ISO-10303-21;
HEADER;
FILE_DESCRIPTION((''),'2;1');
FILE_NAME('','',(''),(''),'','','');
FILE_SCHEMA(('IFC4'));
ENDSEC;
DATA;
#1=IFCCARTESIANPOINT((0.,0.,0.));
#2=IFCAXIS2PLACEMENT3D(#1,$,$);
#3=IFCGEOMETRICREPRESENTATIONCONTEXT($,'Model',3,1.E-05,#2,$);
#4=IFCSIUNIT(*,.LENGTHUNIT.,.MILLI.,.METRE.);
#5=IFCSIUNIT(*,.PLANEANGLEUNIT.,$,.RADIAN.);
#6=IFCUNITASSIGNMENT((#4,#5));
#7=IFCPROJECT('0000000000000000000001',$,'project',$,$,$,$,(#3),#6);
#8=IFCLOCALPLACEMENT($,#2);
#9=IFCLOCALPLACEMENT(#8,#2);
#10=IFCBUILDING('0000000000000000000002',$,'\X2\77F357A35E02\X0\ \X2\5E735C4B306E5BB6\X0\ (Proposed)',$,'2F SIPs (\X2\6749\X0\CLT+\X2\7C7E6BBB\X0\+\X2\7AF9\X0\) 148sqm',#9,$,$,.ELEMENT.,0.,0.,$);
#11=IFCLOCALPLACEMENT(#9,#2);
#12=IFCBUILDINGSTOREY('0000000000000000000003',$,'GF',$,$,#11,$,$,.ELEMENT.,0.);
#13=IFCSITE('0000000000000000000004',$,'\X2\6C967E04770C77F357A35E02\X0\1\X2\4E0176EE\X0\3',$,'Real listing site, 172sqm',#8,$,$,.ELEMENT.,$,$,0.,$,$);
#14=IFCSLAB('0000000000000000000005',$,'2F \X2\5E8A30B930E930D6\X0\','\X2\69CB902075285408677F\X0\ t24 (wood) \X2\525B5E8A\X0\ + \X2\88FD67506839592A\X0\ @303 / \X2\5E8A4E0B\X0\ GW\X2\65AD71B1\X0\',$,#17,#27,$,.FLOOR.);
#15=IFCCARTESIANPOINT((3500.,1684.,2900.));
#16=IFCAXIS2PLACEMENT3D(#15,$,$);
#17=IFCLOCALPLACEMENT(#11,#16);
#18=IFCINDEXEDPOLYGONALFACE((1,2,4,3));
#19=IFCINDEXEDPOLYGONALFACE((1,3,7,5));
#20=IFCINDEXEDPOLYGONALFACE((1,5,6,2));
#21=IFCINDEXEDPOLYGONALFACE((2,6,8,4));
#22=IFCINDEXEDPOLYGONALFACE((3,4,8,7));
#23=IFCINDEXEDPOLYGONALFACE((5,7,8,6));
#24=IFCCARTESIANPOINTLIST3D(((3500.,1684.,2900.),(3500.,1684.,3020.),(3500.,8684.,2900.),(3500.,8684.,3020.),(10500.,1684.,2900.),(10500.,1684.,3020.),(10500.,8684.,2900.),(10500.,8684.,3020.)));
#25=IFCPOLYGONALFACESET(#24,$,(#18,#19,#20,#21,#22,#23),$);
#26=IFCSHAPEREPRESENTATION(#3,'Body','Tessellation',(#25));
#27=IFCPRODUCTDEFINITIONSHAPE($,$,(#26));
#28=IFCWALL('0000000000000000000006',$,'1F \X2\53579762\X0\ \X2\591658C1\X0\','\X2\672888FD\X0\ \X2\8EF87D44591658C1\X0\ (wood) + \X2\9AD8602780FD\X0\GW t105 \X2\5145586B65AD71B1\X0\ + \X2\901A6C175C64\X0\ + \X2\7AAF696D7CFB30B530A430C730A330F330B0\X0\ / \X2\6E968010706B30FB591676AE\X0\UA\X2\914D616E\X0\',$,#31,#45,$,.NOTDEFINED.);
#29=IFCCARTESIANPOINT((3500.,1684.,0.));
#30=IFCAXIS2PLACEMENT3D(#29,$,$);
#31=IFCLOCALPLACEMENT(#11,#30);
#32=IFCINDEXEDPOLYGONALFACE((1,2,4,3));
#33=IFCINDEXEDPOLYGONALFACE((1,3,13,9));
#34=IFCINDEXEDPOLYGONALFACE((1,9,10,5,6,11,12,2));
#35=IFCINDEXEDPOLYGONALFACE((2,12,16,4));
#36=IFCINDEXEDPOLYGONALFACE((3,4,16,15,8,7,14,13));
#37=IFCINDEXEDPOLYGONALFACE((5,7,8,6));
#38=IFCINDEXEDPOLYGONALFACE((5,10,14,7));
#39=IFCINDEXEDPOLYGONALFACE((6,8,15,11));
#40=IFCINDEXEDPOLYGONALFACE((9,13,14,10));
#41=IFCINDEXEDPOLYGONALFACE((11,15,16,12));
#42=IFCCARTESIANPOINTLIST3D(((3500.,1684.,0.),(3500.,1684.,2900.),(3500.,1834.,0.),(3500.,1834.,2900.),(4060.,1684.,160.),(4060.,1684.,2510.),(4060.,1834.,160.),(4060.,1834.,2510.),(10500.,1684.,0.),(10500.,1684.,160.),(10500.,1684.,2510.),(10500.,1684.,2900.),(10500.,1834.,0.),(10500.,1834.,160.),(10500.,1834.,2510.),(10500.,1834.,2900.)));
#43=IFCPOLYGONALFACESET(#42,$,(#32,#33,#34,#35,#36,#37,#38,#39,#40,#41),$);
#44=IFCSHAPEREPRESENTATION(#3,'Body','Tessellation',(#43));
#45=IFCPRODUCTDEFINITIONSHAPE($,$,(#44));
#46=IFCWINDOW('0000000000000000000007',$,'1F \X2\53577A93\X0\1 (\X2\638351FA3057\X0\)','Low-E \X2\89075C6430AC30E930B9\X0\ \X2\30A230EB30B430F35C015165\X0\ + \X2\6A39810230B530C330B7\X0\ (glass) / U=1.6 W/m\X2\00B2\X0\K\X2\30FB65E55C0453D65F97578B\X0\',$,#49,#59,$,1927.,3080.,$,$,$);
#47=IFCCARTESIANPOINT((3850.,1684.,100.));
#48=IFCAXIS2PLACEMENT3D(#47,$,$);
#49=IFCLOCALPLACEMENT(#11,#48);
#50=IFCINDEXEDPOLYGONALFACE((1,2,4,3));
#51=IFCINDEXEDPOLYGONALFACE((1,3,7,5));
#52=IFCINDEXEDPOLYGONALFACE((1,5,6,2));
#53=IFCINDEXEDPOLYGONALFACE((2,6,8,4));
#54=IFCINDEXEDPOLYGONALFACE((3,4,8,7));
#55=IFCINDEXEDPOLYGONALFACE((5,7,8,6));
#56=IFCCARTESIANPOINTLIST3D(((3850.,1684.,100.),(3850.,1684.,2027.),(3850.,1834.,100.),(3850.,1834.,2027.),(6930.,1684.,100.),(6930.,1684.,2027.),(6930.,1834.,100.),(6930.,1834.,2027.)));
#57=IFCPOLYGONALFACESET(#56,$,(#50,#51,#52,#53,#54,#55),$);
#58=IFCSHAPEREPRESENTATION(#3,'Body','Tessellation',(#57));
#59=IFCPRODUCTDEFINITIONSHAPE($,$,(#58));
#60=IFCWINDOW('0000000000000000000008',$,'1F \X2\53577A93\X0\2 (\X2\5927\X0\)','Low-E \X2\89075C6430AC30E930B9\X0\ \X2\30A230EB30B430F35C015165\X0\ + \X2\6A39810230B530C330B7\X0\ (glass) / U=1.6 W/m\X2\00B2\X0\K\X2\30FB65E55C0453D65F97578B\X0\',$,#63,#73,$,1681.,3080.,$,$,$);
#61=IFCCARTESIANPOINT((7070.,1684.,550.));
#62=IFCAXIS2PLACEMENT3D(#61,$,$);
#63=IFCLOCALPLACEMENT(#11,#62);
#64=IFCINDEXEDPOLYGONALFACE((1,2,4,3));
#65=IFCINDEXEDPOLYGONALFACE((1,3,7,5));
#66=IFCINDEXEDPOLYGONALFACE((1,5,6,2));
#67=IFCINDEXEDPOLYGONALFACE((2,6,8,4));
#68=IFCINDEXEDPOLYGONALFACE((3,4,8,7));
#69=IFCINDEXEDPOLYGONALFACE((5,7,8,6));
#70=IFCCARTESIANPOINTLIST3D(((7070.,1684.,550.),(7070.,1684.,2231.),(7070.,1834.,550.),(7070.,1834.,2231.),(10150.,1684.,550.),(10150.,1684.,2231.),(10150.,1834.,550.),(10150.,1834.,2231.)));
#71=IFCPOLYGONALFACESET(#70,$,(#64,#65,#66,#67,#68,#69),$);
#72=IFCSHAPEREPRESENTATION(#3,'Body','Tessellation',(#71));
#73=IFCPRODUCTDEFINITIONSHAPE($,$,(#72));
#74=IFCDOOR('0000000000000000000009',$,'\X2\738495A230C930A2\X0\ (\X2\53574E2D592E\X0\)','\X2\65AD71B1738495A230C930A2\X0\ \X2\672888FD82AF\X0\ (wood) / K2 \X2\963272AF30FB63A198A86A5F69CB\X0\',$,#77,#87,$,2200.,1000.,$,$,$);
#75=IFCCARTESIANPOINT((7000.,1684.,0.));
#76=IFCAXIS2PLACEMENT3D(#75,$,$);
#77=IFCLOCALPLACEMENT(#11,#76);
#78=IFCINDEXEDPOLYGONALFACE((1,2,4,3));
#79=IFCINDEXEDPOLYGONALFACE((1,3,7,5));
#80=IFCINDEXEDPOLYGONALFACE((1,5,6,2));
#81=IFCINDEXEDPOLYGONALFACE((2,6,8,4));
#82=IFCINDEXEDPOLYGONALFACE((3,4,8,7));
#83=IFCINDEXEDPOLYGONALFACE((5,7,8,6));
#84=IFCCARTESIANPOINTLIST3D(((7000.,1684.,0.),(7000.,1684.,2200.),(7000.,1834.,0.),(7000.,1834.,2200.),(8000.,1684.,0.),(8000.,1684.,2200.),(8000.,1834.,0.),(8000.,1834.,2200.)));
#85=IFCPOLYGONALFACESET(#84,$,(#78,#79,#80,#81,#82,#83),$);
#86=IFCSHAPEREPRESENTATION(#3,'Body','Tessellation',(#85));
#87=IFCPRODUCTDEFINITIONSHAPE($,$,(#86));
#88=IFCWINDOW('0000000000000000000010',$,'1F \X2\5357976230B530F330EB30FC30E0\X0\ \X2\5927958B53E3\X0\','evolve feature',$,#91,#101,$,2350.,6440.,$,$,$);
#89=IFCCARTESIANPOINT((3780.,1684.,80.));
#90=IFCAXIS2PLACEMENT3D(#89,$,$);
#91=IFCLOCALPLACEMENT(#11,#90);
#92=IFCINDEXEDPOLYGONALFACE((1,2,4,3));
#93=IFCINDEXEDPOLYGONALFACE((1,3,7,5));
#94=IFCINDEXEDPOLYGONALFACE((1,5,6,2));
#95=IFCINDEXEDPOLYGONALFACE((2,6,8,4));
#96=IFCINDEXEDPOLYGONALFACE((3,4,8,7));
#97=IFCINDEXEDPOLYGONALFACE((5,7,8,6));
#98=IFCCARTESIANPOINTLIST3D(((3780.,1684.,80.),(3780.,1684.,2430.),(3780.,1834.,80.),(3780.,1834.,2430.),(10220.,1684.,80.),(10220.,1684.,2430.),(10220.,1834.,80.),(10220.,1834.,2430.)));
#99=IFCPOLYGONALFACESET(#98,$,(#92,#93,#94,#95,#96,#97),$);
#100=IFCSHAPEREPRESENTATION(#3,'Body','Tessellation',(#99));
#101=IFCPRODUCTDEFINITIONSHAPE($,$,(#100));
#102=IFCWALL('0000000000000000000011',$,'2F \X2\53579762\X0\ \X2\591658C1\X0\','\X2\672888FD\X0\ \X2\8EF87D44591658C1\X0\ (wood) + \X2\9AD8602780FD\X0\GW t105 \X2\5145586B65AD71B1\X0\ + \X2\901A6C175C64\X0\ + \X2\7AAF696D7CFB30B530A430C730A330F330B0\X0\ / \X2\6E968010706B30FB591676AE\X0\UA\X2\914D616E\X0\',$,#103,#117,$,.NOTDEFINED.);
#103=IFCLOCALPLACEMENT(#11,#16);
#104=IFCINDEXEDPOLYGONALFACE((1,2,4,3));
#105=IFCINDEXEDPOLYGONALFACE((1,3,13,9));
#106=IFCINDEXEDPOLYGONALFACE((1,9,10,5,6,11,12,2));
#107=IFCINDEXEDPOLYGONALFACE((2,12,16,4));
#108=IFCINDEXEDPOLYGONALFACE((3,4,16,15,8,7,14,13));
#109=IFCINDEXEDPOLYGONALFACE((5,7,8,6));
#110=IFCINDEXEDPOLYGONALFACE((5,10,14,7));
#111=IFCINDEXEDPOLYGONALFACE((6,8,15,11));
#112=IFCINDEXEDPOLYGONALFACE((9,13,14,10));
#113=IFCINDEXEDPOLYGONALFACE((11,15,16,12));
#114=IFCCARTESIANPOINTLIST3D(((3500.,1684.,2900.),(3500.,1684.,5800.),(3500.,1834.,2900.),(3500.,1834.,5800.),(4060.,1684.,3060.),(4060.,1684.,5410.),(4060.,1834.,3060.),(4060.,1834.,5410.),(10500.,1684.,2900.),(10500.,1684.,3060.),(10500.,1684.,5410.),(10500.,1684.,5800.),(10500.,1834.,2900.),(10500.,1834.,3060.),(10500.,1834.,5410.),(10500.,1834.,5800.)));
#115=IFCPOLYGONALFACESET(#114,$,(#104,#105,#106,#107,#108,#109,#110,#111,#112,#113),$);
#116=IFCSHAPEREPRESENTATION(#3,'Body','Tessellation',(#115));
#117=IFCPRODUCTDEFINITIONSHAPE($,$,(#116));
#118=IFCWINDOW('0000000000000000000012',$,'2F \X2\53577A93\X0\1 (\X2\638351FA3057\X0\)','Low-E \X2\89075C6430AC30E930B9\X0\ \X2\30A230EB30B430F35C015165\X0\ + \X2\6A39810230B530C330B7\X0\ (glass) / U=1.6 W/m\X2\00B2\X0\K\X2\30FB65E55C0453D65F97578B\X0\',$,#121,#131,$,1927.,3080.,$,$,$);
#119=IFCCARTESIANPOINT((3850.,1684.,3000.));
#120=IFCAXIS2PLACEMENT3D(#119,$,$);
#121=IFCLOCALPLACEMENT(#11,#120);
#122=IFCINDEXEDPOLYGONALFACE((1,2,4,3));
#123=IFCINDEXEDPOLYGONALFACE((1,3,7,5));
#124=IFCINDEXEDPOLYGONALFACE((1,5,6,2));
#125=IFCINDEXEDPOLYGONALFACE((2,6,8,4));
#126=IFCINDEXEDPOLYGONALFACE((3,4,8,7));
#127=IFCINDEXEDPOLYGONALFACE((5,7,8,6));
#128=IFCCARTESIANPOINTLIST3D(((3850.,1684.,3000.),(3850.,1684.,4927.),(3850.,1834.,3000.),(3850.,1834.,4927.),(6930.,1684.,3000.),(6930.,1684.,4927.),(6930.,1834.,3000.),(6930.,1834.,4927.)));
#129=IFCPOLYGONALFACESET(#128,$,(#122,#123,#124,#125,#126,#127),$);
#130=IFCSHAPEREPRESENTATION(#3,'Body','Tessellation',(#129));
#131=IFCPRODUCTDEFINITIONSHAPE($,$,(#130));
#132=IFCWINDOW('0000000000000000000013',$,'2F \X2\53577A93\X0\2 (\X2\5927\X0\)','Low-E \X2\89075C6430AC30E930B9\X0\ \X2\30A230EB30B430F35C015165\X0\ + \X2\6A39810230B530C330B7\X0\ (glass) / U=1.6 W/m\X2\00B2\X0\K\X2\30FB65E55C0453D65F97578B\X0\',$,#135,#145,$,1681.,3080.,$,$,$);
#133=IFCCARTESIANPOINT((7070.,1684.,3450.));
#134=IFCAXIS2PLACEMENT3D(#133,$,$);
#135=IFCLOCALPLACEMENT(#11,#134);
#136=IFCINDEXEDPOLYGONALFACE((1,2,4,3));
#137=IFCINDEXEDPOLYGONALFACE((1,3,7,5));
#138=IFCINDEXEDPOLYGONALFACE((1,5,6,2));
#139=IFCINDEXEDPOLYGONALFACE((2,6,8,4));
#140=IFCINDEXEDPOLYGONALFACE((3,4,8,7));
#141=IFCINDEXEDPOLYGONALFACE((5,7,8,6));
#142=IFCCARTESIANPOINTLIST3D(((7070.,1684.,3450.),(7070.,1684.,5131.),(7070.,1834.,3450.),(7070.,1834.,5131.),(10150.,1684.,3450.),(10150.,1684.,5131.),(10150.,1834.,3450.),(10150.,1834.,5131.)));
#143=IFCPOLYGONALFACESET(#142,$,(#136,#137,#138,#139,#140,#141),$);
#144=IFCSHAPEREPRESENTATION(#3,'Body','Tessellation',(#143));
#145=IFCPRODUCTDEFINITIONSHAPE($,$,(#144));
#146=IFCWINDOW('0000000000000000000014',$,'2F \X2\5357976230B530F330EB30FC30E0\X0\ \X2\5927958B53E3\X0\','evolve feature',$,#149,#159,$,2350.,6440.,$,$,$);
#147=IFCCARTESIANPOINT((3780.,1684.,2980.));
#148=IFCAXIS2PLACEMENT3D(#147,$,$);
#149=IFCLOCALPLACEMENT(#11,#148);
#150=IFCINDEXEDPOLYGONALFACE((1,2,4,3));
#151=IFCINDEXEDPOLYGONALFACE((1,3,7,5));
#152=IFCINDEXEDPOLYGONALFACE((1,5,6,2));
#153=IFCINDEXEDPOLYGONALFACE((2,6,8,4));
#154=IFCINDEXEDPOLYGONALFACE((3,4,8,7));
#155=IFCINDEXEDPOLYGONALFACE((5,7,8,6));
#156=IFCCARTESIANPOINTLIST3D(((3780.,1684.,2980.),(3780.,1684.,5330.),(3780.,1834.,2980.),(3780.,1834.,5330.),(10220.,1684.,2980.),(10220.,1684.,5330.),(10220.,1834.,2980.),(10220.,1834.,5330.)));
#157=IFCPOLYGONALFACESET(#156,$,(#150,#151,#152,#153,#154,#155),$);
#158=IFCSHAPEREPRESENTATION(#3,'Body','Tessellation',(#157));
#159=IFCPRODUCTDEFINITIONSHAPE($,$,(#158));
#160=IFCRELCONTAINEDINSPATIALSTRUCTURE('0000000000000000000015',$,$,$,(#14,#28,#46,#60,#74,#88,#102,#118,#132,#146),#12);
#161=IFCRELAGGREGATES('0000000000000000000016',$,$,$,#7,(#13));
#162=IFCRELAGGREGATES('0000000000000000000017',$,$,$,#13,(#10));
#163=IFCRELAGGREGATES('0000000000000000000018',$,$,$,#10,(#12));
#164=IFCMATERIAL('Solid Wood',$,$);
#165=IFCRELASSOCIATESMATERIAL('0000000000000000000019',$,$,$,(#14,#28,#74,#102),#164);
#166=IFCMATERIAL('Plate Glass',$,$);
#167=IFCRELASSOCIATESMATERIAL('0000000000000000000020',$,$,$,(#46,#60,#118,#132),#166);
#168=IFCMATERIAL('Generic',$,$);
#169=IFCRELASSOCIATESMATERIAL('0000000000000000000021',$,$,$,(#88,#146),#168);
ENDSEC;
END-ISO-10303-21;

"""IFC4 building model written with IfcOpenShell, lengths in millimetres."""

from ifc_helpers import new_model, si_unit, frame, frame_2d, origin, place, context, project, spatial, rectangle, extrude, material, element, fill, save


model = new_model("IFC4")

# Units and contexts
model_context = context("Model", 3, precision=1e-05, world=origin())
ifc_project = project(units=[si_unit("LENGTHUNIT", "METRE", prefix="MILLI"), si_unit("PLANEANGLEUNIT", "RADIAN")], contexts=[model_context])

# Site, building, storey
site_placement = place(None, origin())
site = spatial("IfcSite", under=ifc_project, at=site_placement, Name="沖縄県石垣市1丁目3", ObjectType="Real listing site, 172sqm", CompositionType="ELEMENT", RefElevation=0.0)
building_placement = place(site_placement, origin())
building = spatial("IfcBuilding", under=site, at=building_placement, Name="石垣市 平屋の家 (Proposed)", ObjectType="2F SIPs (杉CLT+籾殻+竹) 148sqm", CompositionType="ELEMENT", ElevationOfRefHeight=0.0, ElevationOfTerrain=0.0)
storey_placement = place(building_placement, origin())
storey = spatial("IfcBuildingStorey", under=building, at=storey_placement, Name="GF", CompositionType="ELEMENT", Elevation=0.0)

# Slab
ifc_material_1 = material(Name="Solid Wood")
slab_1_placement = place(storey_placement, frame((3500.0, 1684.0, 2900.0)))
element("IfcSlab", 1, at=slab_1_placement, inside=storey, material=ifc_material_1, Name="2F 床スラブ", Description="構造用合板 t24 (wood) 剛床 + 製材根太 @303 / 床下 GW断熱", PredefinedType="FLOOR", context=model_context, shape_type="SweptSolid", body=[
    extrude(rectangle(XDim=7000.0, YDim=7000.0, at=frame_2d((3500.0, 3500.0))), frame((3500.0, 1684.0, 2900.0)), (0.0, 0.0, 1.0), 120.0),
])
ifc_material_2 = material(Name="Generic")

# Wall, openings, windows, door
wall_1_placement = place(storey_placement, frame((3500.0, 1684.0, 0.0)))
wall_1 = element("IfcWall", 2, at=wall_1_placement, inside=storey, material=ifc_material_1, Name="1F 南面 外壁", Description="木製 軸組外壁 (wood) + 高性能GW t105 充填断熱 + 通気層 + 窯業系サイディング / 準耐火・外皮UA配慮", PredefinedType="NOTDEFINED", context=model_context, shape_type="SweptSolid", body=[
    extrude(rectangle(XDim=7000.0, YDim=150.0, at=frame_2d((3500.0, 75.0))), frame((3500.0, 1684.0, 0.0)), (0.0, 0.0, 1.0), 2900.0),
])
opening_1_placement = place(storey_placement, frame((3850.0, 1684.0, 100.0)))
opening_1 = element("IfcOpeningElement", 3, at=opening_1_placement, cuts=wall_1, PredefinedType="NOTDEFINED", context=model_context, shape_type="SweptSolid", body=[
    extrude(rectangle(XDim=3080.0, YDim=150.0, at=frame_2d((1540.0, 75.0))), frame((3850.0, 1684.0, 100.0)), (0.0, 0.0, 1.0), 1927.0),
])
opening_2_placement = place(storey_placement, frame((7070.0, 1684.0, 550.0)))
opening_2 = element("IfcOpeningElement", 4, at=opening_2_placement, cuts=wall_1, PredefinedType="NOTDEFINED", context=model_context, shape_type="SweptSolid", body=[
    extrude(rectangle(XDim=3080.0, YDim=150.0, at=frame_2d((1540.0, 75.0))), frame((7070.0, 1684.0, 550.0)), (0.0, 0.0, 1.0), 1681.0),
])
opening_3_placement = place(storey_placement, frame((7000.0, 1684.0, 0.0)))
opening_3 = element("IfcOpeningElement", 5, at=opening_3_placement, cuts=wall_1, PredefinedType="NOTDEFINED", context=model_context, shape_type="SweptSolid", body=[
    extrude(rectangle(XDim=1000.0, YDim=150.0, at=frame_2d((500.0, 75.0))), frame((7000.0, 1684.0, 0.0)), (0.0, 0.0, 1.0), 2200.0),
])
opening_4_placement = place(storey_placement, frame((3780.0, 1684.0, 80.0)))
opening_4 = element("IfcOpeningElement", 6, at=opening_4_placement, cuts=wall_1, PredefinedType="NOTDEFINED", context=model_context, shape_type="SweptSolid", body=[
    extrude(rectangle(XDim=6440.0, YDim=150.0, at=frame_2d((3220.0, 75.0))), frame((3780.0, 1684.0, 80.0)), (0.0, 0.0, 1.0), 2350.0),
])
ifc_material_3 = material(Name="Plate Glass")
window_1_placement = place(storey_placement, frame((3850.0, 1684.0, 100.0)))
window_1 = element("IfcWindow", 7, at=window_1_placement, inside=storey, material=ifc_material_3, Name="1F 南窓1 (掃出し)", Description="Low-E 複層ガラス アルゴン封入 + 樹脂サッシ (glass) / U=1.6 W/m²K・日射取得型", OverallHeight=1927.0, OverallWidth=3080.0, context=model_context, shape_type="SweptSolid", body=[
    extrude(rectangle(XDim=3080.0, YDim=150.0, at=frame_2d((1540.0, 75.0))), frame((3850.0, 1684.0, 100.0)), (0.0, 0.0, 1.0), 1927.0),
])
fill(opening_1, window_1)
window_2_placement = place(storey_placement, frame((7070.0, 1684.0, 550.0)))
window_2 = element("IfcWindow", 8, at=window_2_placement, inside=storey, material=ifc_material_3, Name="1F 南窓2 (大)", Description="Low-E 複層ガラス アルゴン封入 + 樹脂サッシ (glass) / U=1.6 W/m²K・日射取得型", OverallHeight=1681.0, OverallWidth=3080.0, context=model_context, shape_type="SweptSolid", body=[
    extrude(rectangle(XDim=3080.0, YDim=150.0, at=frame_2d((1540.0, 75.0))), frame((7070.0, 1684.0, 550.0)), (0.0, 0.0, 1.0), 1681.0),
])
fill(opening_2, window_2)
door_placement = place(storey_placement, frame((7000.0, 1684.0, 0.0)))
door = element("IfcDoor", 9, at=door_placement, inside=storey, material=ifc_material_1, Name="玄関ドア (南中央)", Description="断熱玄関ドア 木製芯 (wood) / K2 防犯・採風機構", OverallHeight=2200.0, OverallWidth=1000.0, context=model_context, shape_type="SweptSolid", body=[
    extrude(rectangle(XDim=1000.0, YDim=150.0, at=frame_2d((500.0, 75.0))), frame((7000.0, 1684.0, 0.0)), (0.0, 0.0, 1.0), 2200.0),
])
fill(opening_3, door)
window_3_placement = place(storey_placement, frame((3780.0, 1684.0, 80.0)))
window_3 = element("IfcWindow", 10, at=window_3_placement, inside=storey, material=ifc_material_2, Name="1F 南面サンルーム 大開口", Description="evolve feature", OverallHeight=2350.0, OverallWidth=6440.0, context=model_context, shape_type="SweptSolid", body=[
    extrude(rectangle(XDim=6440.0, YDim=150.0, at=frame_2d((3220.0, 75.0))), frame((3780.0, 1684.0, 80.0)), (0.0, 0.0, 1.0), 2350.0),
])
fill(opening_4, window_3)

# Wall, openings, windows
wall_2_placement = place(storey_placement, frame((3500.0, 1684.0, 2900.0)))
wall_2 = element("IfcWall", 11, at=wall_2_placement, inside=storey, material=ifc_material_1, Name="2F 南面 外壁", Description="木製 軸組外壁 (wood) + 高性能GW t105 充填断熱 + 通気層 + 窯業系サイディング / 準耐火・外皮UA配慮", PredefinedType="NOTDEFINED", context=model_context, shape_type="SweptSolid", body=[
    extrude(rectangle(XDim=7000.0, YDim=150.0, at=frame_2d((3500.0, 75.0))), frame((3500.0, 1684.0, 2900.0)), (0.0, 0.0, 1.0), 2900.0),
])
opening_5_placement = place(storey_placement, frame((3850.0, 1684.0, 3000.0)))
opening_5 = element("IfcOpeningElement", 12, at=opening_5_placement, cuts=wall_2, PredefinedType="NOTDEFINED", context=model_context, shape_type="SweptSolid", body=[
    extrude(rectangle(XDim=3080.0, YDim=150.0, at=frame_2d((1540.0, 75.0))), frame((3850.0, 1684.0, 3000.0)), (0.0, 0.0, 1.0), 1927.0),
])
opening_6_placement = place(storey_placement, frame((7070.0, 1684.0, 3450.0)))
opening_6 = element("IfcOpeningElement", 13, at=opening_6_placement, cuts=wall_2, PredefinedType="NOTDEFINED", context=model_context, shape_type="SweptSolid", body=[
    extrude(rectangle(XDim=3080.0, YDim=150.0, at=frame_2d((1540.0, 75.0))), frame((7070.0, 1684.0, 3450.0)), (0.0, 0.0, 1.0), 1681.0),
])
opening_7_placement = place(storey_placement, frame((3780.0, 1684.0, 2980.0)))
opening_7 = element("IfcOpeningElement", 14, at=opening_7_placement, cuts=wall_2, PredefinedType="NOTDEFINED", context=model_context, shape_type="SweptSolid", body=[
    extrude(rectangle(XDim=6440.0, YDim=150.0, at=frame_2d((3220.0, 75.0))), frame((3780.0, 1684.0, 2980.0)), (0.0, 0.0, 1.0), 2350.0),
])
window_4_placement = place(storey_placement, frame((3850.0, 1684.0, 3000.0)))
window_4 = element("IfcWindow", 15, at=window_4_placement, inside=storey, material=ifc_material_3, Name="2F 南窓1 (掃出し)", Description="Low-E 複層ガラス アルゴン封入 + 樹脂サッシ (glass) / U=1.6 W/m²K・日射取得型", OverallHeight=1927.0, OverallWidth=3080.0, context=model_context, shape_type="SweptSolid", body=[
    extrude(rectangle(XDim=3080.0, YDim=150.0, at=frame_2d((1540.0, 75.0))), frame((3850.0, 1684.0, 3000.0)), (0.0, 0.0, 1.0), 1927.0),
])
fill(opening_5, window_4)
window_5_placement = place(storey_placement, frame((7070.0, 1684.0, 3450.0)))
window_5 = element("IfcWindow", 16, at=window_5_placement, inside=storey, material=ifc_material_3, Name="2F 南窓2 (大)", Description="Low-E 複層ガラス アルゴン封入 + 樹脂サッシ (glass) / U=1.6 W/m²K・日射取得型", OverallHeight=1681.0, OverallWidth=3080.0, context=model_context, shape_type="SweptSolid", body=[
    extrude(rectangle(XDim=3080.0, YDim=150.0, at=frame_2d((1540.0, 75.0))), frame((7070.0, 1684.0, 3450.0)), (0.0, 0.0, 1.0), 1681.0),
])
fill(opening_6, window_5)
window_6_placement = place(storey_placement, frame((3780.0, 1684.0, 2980.0)))
window_6 = element("IfcWindow", 17, at=window_6_placement, inside=storey, material=ifc_material_2, Name="2F 南面サンルーム 大開口", Description="evolve feature", OverallHeight=2350.0, OverallWidth=6440.0, context=model_context, shape_type="SweptSolid", body=[
    extrude(rectangle(XDim=6440.0, YDim=150.0, at=frame_2d((3220.0, 75.0))), frame((3780.0, 1684.0, 2980.0)), (0.0, 0.0, 1.0), 2350.0),
])
fill(opening_7, window_6)

save(model, "model.ifc")
